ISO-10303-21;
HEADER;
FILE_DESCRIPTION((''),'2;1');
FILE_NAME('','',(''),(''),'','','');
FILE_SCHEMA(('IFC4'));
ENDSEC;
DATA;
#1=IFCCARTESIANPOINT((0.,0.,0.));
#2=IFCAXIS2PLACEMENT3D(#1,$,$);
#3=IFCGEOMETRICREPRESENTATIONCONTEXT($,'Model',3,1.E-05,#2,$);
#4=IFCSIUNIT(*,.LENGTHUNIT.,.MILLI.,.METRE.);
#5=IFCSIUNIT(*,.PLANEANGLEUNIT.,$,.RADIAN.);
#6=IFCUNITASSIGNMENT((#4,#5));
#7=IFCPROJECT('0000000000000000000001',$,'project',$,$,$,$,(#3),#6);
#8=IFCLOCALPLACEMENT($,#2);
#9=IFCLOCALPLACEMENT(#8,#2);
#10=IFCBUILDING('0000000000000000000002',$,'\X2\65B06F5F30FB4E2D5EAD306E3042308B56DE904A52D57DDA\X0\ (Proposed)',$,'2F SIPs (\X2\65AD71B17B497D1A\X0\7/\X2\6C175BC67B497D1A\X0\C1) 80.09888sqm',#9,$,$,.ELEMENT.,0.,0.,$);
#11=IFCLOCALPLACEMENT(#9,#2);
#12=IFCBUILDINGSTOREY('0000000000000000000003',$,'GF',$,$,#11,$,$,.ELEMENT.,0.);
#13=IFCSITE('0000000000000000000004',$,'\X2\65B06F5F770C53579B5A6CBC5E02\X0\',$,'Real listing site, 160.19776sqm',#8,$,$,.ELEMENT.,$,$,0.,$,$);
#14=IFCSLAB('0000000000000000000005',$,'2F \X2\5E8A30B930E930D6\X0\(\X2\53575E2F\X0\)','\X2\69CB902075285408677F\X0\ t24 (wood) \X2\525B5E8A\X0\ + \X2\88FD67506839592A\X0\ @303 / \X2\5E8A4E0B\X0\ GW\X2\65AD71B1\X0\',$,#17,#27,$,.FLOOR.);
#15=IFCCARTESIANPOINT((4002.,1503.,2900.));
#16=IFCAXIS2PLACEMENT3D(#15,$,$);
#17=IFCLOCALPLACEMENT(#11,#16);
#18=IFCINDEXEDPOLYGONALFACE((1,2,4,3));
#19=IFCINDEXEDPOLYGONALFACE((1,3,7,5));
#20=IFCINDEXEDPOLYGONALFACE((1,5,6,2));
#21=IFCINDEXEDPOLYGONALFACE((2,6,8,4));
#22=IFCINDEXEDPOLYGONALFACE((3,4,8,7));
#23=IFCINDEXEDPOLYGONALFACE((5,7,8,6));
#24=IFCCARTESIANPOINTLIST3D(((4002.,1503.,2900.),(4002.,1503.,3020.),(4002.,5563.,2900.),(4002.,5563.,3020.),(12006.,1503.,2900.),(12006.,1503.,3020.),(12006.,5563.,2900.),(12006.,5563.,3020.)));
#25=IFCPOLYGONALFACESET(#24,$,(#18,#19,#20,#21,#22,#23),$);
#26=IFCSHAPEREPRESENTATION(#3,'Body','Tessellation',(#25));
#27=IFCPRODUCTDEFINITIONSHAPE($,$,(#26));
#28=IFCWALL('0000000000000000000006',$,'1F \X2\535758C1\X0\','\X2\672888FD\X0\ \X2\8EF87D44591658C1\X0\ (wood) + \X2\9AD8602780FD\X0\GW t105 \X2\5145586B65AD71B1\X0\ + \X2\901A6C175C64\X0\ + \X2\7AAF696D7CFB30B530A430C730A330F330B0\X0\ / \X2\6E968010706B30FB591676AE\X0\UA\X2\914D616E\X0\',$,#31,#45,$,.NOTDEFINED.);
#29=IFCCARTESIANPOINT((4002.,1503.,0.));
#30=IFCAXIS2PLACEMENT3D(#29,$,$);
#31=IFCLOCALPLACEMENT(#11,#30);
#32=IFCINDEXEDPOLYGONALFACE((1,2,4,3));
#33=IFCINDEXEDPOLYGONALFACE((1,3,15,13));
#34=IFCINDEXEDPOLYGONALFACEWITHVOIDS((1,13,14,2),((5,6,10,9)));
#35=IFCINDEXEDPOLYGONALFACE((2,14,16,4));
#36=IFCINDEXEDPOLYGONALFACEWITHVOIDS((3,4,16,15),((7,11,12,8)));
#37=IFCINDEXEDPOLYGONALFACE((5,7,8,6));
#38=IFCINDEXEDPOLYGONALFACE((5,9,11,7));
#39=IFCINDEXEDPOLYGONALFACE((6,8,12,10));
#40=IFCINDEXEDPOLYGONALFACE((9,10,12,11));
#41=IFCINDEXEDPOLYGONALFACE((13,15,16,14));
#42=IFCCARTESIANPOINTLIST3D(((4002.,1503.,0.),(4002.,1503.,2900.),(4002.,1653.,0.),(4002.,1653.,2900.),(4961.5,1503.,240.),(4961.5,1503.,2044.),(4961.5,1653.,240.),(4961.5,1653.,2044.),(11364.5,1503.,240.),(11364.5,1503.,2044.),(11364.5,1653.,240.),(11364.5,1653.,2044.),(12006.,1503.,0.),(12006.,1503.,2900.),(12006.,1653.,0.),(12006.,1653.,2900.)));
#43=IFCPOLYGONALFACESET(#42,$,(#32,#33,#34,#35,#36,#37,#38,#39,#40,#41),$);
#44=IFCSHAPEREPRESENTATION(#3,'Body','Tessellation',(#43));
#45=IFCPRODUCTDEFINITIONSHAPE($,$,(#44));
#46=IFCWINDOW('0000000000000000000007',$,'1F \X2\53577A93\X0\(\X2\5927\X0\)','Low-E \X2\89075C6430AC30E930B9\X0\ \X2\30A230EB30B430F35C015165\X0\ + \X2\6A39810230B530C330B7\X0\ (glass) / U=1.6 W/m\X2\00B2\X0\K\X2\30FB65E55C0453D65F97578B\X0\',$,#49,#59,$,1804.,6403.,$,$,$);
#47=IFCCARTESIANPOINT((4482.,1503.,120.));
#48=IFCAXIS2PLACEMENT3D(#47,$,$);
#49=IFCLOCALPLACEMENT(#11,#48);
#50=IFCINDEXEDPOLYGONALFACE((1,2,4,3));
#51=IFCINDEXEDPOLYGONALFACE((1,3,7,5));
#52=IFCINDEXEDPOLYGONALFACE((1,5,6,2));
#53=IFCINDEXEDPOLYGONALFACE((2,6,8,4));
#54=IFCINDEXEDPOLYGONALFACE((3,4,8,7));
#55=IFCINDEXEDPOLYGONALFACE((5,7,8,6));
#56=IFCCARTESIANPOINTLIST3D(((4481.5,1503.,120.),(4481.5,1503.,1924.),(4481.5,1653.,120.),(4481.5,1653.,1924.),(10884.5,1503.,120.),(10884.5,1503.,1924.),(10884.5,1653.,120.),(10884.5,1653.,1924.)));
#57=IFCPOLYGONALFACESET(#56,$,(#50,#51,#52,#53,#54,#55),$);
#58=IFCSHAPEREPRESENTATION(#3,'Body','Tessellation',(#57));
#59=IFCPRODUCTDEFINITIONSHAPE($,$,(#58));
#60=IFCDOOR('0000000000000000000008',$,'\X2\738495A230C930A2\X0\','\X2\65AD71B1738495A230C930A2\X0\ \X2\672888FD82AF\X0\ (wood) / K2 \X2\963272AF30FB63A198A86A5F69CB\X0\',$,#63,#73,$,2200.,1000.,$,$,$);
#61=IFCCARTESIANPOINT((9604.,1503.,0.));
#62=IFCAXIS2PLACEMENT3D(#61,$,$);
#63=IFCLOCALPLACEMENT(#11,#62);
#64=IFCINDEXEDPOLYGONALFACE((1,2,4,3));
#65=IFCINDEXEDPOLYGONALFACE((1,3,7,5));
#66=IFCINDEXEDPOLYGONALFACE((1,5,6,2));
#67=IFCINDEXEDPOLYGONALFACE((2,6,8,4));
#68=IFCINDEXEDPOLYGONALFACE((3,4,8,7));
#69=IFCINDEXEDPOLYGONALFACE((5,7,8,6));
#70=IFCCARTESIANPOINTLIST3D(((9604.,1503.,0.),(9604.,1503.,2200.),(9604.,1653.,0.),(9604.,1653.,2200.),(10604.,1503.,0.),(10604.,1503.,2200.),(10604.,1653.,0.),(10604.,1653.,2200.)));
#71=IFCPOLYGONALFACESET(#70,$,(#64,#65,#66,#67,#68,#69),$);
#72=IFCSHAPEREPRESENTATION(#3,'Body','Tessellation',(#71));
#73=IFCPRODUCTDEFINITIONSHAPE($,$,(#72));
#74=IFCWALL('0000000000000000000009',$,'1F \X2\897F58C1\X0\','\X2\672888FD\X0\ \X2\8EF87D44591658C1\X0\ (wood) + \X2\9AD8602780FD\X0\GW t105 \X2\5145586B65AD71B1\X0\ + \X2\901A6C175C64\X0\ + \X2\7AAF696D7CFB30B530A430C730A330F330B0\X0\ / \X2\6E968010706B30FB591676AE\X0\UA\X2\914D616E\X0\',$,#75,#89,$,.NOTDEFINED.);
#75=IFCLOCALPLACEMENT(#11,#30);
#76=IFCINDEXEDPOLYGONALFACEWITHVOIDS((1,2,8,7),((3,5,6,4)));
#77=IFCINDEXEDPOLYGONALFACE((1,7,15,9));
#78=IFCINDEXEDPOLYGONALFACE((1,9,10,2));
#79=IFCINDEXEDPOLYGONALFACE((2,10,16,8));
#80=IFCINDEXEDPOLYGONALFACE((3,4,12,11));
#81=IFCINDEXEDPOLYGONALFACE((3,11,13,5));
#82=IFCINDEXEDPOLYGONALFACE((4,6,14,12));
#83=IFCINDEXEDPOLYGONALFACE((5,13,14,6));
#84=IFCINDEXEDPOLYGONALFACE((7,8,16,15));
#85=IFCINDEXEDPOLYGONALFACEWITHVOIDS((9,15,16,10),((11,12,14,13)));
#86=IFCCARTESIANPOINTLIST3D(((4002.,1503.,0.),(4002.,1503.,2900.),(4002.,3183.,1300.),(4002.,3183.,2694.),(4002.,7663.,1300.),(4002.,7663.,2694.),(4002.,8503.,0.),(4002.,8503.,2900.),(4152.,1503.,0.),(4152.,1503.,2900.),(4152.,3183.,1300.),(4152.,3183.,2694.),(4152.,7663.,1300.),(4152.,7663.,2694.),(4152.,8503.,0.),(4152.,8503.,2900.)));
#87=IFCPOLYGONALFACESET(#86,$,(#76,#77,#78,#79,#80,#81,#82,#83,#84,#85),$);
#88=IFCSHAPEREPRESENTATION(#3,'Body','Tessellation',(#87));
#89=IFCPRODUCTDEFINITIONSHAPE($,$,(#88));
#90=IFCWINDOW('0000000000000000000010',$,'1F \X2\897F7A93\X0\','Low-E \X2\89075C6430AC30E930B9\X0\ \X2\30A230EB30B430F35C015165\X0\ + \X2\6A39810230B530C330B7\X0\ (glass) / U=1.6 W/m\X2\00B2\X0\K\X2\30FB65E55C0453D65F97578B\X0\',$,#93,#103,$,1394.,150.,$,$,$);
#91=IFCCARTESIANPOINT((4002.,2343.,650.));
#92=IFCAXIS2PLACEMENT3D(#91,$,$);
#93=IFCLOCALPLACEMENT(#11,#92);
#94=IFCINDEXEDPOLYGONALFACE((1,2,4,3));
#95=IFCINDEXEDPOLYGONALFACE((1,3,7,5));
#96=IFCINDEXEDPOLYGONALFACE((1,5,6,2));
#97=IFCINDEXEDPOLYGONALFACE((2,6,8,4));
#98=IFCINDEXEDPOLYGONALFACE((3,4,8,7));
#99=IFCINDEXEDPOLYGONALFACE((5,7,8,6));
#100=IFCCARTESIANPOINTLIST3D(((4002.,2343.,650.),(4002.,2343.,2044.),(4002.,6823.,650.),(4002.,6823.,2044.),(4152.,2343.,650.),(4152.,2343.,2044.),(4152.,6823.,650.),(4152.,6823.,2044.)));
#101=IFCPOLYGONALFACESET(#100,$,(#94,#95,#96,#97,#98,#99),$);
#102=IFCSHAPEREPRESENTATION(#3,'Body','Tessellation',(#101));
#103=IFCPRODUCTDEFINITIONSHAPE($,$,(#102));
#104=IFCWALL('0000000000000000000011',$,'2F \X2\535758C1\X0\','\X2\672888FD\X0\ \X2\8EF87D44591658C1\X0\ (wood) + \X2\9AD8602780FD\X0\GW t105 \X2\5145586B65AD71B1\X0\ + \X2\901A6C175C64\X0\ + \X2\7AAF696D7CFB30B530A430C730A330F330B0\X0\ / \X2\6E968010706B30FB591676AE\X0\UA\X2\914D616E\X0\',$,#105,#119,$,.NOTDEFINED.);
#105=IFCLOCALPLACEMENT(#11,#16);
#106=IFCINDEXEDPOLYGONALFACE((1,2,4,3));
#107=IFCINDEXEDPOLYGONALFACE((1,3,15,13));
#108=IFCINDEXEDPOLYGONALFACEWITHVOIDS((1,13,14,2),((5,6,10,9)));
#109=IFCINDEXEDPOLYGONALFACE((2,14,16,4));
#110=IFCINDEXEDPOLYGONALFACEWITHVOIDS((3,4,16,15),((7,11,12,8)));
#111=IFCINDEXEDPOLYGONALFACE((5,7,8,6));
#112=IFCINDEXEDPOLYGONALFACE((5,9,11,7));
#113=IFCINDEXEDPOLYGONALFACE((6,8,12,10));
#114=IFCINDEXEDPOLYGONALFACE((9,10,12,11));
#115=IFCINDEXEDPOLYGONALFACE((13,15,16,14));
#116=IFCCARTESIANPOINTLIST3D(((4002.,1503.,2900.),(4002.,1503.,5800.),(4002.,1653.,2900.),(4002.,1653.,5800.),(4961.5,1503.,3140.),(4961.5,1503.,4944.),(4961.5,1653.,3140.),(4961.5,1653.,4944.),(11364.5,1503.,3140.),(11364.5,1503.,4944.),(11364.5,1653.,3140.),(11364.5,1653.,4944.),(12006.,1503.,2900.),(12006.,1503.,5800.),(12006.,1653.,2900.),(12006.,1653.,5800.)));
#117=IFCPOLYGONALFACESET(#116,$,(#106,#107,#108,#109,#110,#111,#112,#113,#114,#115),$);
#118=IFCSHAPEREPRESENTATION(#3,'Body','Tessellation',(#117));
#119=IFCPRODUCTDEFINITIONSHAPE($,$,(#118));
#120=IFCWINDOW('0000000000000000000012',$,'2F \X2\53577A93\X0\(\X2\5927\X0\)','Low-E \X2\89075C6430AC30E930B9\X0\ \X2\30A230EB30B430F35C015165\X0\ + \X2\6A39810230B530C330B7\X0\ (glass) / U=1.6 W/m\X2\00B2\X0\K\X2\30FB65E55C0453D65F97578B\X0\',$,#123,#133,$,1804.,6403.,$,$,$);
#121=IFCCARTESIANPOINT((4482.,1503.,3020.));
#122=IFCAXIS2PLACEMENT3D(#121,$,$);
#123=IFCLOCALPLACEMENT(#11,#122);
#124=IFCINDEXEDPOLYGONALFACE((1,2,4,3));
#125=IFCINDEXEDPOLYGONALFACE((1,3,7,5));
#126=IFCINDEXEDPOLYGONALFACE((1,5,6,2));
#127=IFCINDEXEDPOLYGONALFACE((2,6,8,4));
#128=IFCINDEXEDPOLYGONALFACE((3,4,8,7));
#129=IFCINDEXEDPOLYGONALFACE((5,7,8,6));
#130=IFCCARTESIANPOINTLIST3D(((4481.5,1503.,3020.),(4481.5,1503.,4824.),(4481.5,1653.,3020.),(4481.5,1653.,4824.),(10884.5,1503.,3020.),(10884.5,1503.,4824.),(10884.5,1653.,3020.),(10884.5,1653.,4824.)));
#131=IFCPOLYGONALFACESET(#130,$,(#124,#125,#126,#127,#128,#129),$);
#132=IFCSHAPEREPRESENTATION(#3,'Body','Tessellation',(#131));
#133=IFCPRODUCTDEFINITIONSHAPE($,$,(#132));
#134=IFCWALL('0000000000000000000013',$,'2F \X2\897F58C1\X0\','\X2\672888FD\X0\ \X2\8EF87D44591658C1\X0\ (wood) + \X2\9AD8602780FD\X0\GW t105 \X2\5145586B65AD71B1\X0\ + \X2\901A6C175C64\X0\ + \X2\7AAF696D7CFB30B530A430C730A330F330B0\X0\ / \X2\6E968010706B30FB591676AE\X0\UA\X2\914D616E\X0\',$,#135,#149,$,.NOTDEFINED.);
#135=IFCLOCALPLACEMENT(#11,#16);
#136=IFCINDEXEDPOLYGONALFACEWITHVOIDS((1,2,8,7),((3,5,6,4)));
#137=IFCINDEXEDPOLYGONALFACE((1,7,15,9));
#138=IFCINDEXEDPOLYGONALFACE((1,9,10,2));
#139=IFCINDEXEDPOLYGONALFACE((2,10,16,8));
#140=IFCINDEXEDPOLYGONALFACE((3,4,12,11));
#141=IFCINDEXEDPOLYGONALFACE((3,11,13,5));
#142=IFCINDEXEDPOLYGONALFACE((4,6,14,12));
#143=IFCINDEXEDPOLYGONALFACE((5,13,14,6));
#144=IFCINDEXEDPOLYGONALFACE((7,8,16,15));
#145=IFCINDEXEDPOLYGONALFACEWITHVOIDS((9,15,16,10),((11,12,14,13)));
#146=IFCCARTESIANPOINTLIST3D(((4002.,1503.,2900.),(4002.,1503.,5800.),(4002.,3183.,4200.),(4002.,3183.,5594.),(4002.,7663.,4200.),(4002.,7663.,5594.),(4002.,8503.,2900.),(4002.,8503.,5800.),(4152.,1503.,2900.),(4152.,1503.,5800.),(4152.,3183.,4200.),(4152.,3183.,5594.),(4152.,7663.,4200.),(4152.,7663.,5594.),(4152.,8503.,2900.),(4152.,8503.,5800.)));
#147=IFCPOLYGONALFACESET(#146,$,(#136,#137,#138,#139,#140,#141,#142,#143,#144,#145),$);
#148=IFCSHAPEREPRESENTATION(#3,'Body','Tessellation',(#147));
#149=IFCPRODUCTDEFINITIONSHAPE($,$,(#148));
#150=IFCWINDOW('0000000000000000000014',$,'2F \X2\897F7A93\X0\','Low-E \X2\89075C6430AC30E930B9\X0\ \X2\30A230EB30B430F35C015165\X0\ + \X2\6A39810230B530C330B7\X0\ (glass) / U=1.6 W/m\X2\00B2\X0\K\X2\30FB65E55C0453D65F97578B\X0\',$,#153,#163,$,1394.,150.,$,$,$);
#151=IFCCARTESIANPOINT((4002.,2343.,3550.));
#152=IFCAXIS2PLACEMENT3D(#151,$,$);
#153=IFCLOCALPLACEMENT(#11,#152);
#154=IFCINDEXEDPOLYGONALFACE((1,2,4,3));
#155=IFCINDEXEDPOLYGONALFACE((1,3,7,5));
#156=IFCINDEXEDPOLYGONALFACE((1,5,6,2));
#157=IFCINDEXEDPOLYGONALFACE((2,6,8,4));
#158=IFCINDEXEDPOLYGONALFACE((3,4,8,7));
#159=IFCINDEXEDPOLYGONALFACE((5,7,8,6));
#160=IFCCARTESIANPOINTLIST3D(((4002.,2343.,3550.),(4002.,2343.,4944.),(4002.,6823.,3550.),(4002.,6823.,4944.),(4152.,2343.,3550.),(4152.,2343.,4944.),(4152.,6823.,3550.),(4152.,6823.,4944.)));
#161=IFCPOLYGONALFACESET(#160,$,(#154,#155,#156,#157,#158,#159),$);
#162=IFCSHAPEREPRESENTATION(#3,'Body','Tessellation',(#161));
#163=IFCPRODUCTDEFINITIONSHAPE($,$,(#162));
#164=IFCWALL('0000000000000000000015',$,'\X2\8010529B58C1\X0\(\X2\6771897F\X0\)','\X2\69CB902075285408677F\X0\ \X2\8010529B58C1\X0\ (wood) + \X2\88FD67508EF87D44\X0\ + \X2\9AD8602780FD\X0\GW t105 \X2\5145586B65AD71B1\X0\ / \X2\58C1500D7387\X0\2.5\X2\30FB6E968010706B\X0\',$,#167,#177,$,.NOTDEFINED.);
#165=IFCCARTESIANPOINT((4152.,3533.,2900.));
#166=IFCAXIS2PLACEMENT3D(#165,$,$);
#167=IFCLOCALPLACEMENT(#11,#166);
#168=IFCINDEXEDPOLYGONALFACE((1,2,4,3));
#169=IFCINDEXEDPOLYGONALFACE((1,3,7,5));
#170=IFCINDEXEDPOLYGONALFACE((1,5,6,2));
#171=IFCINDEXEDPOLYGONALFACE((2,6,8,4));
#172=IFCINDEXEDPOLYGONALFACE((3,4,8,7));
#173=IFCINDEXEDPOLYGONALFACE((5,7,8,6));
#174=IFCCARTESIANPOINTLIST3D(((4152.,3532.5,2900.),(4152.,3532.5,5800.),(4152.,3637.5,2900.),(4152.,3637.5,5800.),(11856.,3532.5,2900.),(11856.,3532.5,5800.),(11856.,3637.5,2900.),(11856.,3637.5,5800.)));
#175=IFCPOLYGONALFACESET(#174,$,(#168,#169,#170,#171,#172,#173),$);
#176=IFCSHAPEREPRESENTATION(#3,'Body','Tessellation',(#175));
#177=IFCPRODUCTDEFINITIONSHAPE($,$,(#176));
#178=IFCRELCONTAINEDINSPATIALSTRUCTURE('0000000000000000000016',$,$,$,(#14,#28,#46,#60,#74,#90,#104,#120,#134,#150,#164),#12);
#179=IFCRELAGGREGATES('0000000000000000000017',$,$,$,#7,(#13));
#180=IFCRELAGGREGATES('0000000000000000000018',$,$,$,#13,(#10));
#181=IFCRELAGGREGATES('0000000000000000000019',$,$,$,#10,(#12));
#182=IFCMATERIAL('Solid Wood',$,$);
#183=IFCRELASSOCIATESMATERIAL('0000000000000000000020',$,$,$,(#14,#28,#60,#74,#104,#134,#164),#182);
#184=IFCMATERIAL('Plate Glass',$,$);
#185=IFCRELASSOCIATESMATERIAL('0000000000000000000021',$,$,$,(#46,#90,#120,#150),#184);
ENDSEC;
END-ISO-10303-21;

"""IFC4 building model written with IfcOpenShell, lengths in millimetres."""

from ifc_helpers import new_model, si_unit, frame, frame_2d, origin, place, context, project, spatial, rectangle, extrude, material, element, fill, save


model = new_model("IFC4")

# Units and contexts
model_context = context("Model", 3, precision=1e-05, world=origin())
ifc_project = project(units=[si_unit("LENGTHUNIT", "METRE", prefix="MILLI"), si_unit("PLANEANGLEUNIT", "RADIAN")], contexts=[model_context])

# Site, building, storey
site_placement = place(None, origin())
site = spatial("IfcSite", under=ifc_project, at=site_placement, Name="新潟県南魚沼市", ObjectType="Real listing site, 160.19776sqm", CompositionType="ELEMENT", RefElevation=0.0)
building_placement = place(site_placement, origin())
building = spatial("IfcBuilding", under=site, at=building_placement, Name="新潟・中庭のある回遊動線 (Proposed)", ObjectType="2F SIPs (断熱等級7/気密等級C1) 80.09888sqm", CompositionType="ELEMENT", ElevationOfRefHeight=0.0, ElevationOfTerrain=0.0)
storey_placement = place(building_placement, origin())
storey = spatial("IfcBuildingStorey", under=building, at=storey_placement, Name="GF", CompositionType="ELEMENT", Elevation=0.0)

# Slab
ifc_material_1 = material(Name="Solid Wood")
slab_1_placement = place(storey_placement, frame((4002.0, 1503.0, 2900.0)))
element("IfcSlab", 1, at=slab_1_placement, inside=storey, material=ifc_material_1, Name="2F 床スラブ(南帯)", Description="構造用合板 t24 (wood) 剛床 + 製材根太 @303 / 床下 GW断熱", PredefinedType="FLOOR", context=model_context, shape_type="SweptSolid", body=[
    extrude(rectangle(XDim=8004.0, YDim=4060.0, at=frame_2d((4002.0, 2030.0))), frame((4002.0, 1503.0, 2900.0)), (0.0, 0.0, 1.0), 120.0),
])

# Wall, openings, window, door
wall_1_placement = place(storey_placement, frame((4002.0, 1503.0, 0.0)))
wall_1 = element("IfcWall", 2, at=wall_1_placement, inside=storey, material=ifc_material_1, Name="1F 南壁", Description="木製 軸組外壁 (wood) + 高性能GW t105 充填断熱 + 通気層 + 窯業系サイディング / 準耐火・外皮UA配慮", PredefinedType="NOTDEFINED", context=model_context, shape_type="SweptSolid", body=[
    extrude(rectangle(XDim=8004.0, YDim=150.0, at=frame_2d((4002.0, 75.0))), frame((4002.0, 1503.0, 0.0)), (0.0, 0.0, 1.0), 2900.0),
])
opening_1_placement = place(storey_placement, frame((4482.0, 1503.0, 120.0)))
opening_1 = element("IfcOpeningElement", 3, at=opening_1_placement, cuts=wall_1, PredefinedType="NOTDEFINED", context=model_context, shape_type="SweptSolid", body=[
    extrude(rectangle(XDim=6403.0, YDim=150.0, at=frame_2d((3201.0, 75.0))), frame((4482.0, 1503.0, 120.0)), (0.0, 0.0, 1.0), 1804.0),
])
opening_2_placement = place(storey_placement, frame((9604.0, 1503.0, 0.0)))
opening_2 = element("IfcOpeningElement", 4, at=opening_2_placement, cuts=wall_1, PredefinedType="NOTDEFINED", context=model_context, shape_type="SweptSolid", body=[
    extrude(rectangle(XDim=1000.0, YDim=150.0, at=frame_2d((500.0, 75.0))), frame((9604.0, 1503.0, 0.0)), (0.0, 0.0, 1.0), 2200.0),
])
ifc_material_2 = material(Name="Plate Glass")
window_1_placement = place(storey_placement, frame((4482.0, 1503.0, 120.0)))
window_1 = element("IfcWindow", 5, at=window_1_placement, inside=storey, material=ifc_material_2, Name="1F 南窓(大)", Description="Low-E 複層ガラス アルゴン封入 + 樹脂サッシ (glass) / U=1.6 W/m²K・日射取得型", OverallHeight=1804.0, OverallWidth=6403.0, context=model_context, shape_type="SweptSolid", body=[
    extrude(rectangle(XDim=6403.0, YDim=150.0, at=frame_2d((3201.0, 75.0))), frame((4482.0, 1503.0, 120.0)), (0.0, 0.0, 1.0), 1804.0),
])
fill(opening_1, window_1)
door_placement = place(storey_placement, frame((9604.0, 1503.0, 0.0)))
door = element("IfcDoor", 6, at=door_placement, inside=storey, material=ifc_material_1, Name="玄関ドア", Description="断熱玄関ドア 木製芯 (wood) / K2 防犯・採風機構", OverallHeight=2200.0, OverallWidth=1000.0, context=model_context, shape_type="SweptSolid", body=[
    extrude(rectangle(XDim=1000.0, YDim=150.0, at=frame_2d((500.0, 75.0))), frame((9604.0, 1503.0, 0.0)), (0.0, 0.0, 1.0), 2200.0),
])
fill(opening_2, door)

# Wall, opening, window
wall_2_placement = place(storey_placement, frame((4002.0, 1503.0, 0.0)))
wall_2 = element("IfcWall", 7, at=wall_2_placement, inside=storey, material=ifc_material_1, Name="1F 西壁", Description="木製 軸組外壁 (wood) + 高性能GW t105 充填断熱 + 通気層 + 窯業系サイディング / 準耐火・外皮UA配慮", PredefinedType="NOTDEFINED", context=model_context, shape_type="SweptSolid", body=[
    extrude(rectangle(XDim=150.0, YDim=7000.0, at=frame_2d((75.0, 3500.0))), frame((4002.0, 1503.0, 0.0)), (0.0, 0.0, 1.0), 2900.0),
])
opening_3_placement = place(storey_placement, frame((4002.0, 2343.0, 650.0)))
opening_3 = element("IfcOpeningElement", 8, at=opening_3_placement, cuts=wall_2, PredefinedType="NOTDEFINED", context=model_context, shape_type="SweptSolid", body=[
    extrude(rectangle(XDim=150.0, YDim=4480.0, at=frame_2d((75.0, 2240.0))), frame((4002.0, 2343.0, 650.0)), (0.0, 0.0, 1.0), 1394.0),
])
window_2_placement = place(storey_placement, frame((4002.0, 2343.0, 650.0)))
window_2 = element("IfcWindow", 9, at=window_2_placement, inside=storey, material=ifc_material_2, Name="1F 西窓", Description="Low-E 複層ガラス アルゴン封入 + 樹脂サッシ (glass) / U=1.6 W/m²K・日射取得型", OverallHeight=1394.0, OverallWidth=150.0, context=model_context, shape_type="SweptSolid", body=[
    extrude(rectangle(XDim=150.0, YDim=4480.0, at=frame_2d((75.0, 2240.0))), frame((4002.0, 2343.0, 650.0)), (0.0, 0.0, 1.0), 1394.0),
])
fill(opening_3, window_2)

# Walls, openings, windows
wall_3_placement = place(storey_placement, frame((4002.0, 1503.0, 2900.0)))
wall_3 = element("IfcWall", 10, at=wall_3_placement, inside=storey, material=ifc_material_1, Name="2F 南壁", Description="木製 軸組外壁 (wood) + 高性能GW t105 充填断熱 + 通気層 + 窯業系サイディング / 準耐火・外皮UA配慮", PredefinedType="NOTDEFINED", context=model_context, shape_type="SweptSolid", body=[
    extrude(rectangle(XDim=8004.0, YDim=150.0, at=frame_2d((4002.0, 75.0))), frame((4002.0, 1503.0, 2900.0)), (0.0, 0.0, 1.0), 2900.0),
])
opening_4_placement = place(storey_placement, frame((4482.0, 1503.0, 3020.0)))
opening_4 = element("IfcOpeningElement", 11, at=opening_4_placement, cuts=wall_3, PredefinedType="NOTDEFINED", context=model_context, shape_type="SweptSolid", body=[
    extrude(rectangle(XDim=6403.0, YDim=150.0, at=frame_2d((3201.0, 75.0))), frame((4482.0, 1503.0, 3020.0)), (0.0, 0.0, 1.0), 1804.0),
])
window_3_placement = place(storey_placement, frame((4482.0, 1503.0, 3020.0)))
window_3 = element("IfcWindow", 12, at=window_3_placement, inside=storey, material=ifc_material_2, Name="2F 南窓(大)", Description="Low-E 複層ガラス アルゴン封入 + 樹脂サッシ (glass) / U=1.6 W/m²K・日射取得型", OverallHeight=1804.0, OverallWidth=6403.0, context=model_context, shape_type="SweptSolid", body=[
    extrude(rectangle(XDim=6403.0, YDim=150.0, at=frame_2d((3201.0, 75.0))), frame((4482.0, 1503.0, 3020.0)), (0.0, 0.0, 1.0), 1804.0),
])
fill(opening_4, window_3)
wall_4_placement = place(storey_placement, frame((4002.0, 1503.0, 2900.0)))
wall_4 = element("IfcWall", 13, at=wall_4_placement, inside=storey, material=ifc_material_1, Name="2F 西壁", Description="木製 軸組外壁 (wood) + 高性能GW t105 充填断熱 + 通気層 + 窯業系サイディング / 準耐火・外皮UA配慮", PredefinedType="NOTDEFINED", context=model_context, shape_type="SweptSolid", body=[
    extrude(rectangle(XDim=150.0, YDim=7000.0, at=frame_2d((75.0, 3500.0))), frame((4002.0, 1503.0, 2900.0)), (0.0, 0.0, 1.0), 2900.0),
])
opening_5_placement = place(storey_placement, frame((4002.0, 2343.0, 3550.0)))
opening_5 = element("IfcOpeningElement", 14, at=opening_5_placement, cuts=wall_4, PredefinedType="NOTDEFINED", context=model_context, shape_type="SweptSolid", body=[
    extrude(rectangle(XDim=150.0, YDim=4480.0, at=frame_2d((75.0, 2240.0))), frame((4002.0, 2343.0, 3550.0)), (0.0, 0.0, 1.0), 1394.0),
])
window_4_placement = place(storey_placement, frame((4002.0, 2343.0, 3550.0)))
window_4 = element("IfcWindow", 15, at=window_4_placement, inside=storey, material=ifc_material_2, Name="2F 西窓", Description="Low-E 複層ガラス アルゴン封入 + 樹脂サッシ (glass) / U=1.6 W/m²K・日射取得型", OverallHeight=1394.0, OverallWidth=150.0, context=model_context, shape_type="SweptSolid", body=[
    extrude(rectangle(XDim=150.0, YDim=4480.0, at=frame_2d((75.0, 2240.0))), frame((4002.0, 2343.0, 3550.0)), (0.0, 0.0, 1.0), 1394.0),
])
fill(opening_5, window_4)

# Wall
wall_5_placement = place(storey_placement, frame((4152.0, 3533.0, 2900.0)))
element("IfcWall", 16, at=wall_5_placement, inside=storey, material=ifc_material_1, Name="耐力壁(東西)", Description="構造用合板 耐力壁 (wood) + 製材軸組 + 高性能GW t105 充填断熱 / 壁倍率2.5・準耐火", PredefinedType="NOTDEFINED", context=model_context, shape_type="SweptSolid", body=[
    extrude(rectangle(XDim=7704.0, YDim=105.0, at=frame_2d((3852.0, 52.0))), frame((4152.0, 3533.0, 2900.0)), (0.0, 0.0, 1.0), 2900.0),
])

save(model, "model.ifc")
